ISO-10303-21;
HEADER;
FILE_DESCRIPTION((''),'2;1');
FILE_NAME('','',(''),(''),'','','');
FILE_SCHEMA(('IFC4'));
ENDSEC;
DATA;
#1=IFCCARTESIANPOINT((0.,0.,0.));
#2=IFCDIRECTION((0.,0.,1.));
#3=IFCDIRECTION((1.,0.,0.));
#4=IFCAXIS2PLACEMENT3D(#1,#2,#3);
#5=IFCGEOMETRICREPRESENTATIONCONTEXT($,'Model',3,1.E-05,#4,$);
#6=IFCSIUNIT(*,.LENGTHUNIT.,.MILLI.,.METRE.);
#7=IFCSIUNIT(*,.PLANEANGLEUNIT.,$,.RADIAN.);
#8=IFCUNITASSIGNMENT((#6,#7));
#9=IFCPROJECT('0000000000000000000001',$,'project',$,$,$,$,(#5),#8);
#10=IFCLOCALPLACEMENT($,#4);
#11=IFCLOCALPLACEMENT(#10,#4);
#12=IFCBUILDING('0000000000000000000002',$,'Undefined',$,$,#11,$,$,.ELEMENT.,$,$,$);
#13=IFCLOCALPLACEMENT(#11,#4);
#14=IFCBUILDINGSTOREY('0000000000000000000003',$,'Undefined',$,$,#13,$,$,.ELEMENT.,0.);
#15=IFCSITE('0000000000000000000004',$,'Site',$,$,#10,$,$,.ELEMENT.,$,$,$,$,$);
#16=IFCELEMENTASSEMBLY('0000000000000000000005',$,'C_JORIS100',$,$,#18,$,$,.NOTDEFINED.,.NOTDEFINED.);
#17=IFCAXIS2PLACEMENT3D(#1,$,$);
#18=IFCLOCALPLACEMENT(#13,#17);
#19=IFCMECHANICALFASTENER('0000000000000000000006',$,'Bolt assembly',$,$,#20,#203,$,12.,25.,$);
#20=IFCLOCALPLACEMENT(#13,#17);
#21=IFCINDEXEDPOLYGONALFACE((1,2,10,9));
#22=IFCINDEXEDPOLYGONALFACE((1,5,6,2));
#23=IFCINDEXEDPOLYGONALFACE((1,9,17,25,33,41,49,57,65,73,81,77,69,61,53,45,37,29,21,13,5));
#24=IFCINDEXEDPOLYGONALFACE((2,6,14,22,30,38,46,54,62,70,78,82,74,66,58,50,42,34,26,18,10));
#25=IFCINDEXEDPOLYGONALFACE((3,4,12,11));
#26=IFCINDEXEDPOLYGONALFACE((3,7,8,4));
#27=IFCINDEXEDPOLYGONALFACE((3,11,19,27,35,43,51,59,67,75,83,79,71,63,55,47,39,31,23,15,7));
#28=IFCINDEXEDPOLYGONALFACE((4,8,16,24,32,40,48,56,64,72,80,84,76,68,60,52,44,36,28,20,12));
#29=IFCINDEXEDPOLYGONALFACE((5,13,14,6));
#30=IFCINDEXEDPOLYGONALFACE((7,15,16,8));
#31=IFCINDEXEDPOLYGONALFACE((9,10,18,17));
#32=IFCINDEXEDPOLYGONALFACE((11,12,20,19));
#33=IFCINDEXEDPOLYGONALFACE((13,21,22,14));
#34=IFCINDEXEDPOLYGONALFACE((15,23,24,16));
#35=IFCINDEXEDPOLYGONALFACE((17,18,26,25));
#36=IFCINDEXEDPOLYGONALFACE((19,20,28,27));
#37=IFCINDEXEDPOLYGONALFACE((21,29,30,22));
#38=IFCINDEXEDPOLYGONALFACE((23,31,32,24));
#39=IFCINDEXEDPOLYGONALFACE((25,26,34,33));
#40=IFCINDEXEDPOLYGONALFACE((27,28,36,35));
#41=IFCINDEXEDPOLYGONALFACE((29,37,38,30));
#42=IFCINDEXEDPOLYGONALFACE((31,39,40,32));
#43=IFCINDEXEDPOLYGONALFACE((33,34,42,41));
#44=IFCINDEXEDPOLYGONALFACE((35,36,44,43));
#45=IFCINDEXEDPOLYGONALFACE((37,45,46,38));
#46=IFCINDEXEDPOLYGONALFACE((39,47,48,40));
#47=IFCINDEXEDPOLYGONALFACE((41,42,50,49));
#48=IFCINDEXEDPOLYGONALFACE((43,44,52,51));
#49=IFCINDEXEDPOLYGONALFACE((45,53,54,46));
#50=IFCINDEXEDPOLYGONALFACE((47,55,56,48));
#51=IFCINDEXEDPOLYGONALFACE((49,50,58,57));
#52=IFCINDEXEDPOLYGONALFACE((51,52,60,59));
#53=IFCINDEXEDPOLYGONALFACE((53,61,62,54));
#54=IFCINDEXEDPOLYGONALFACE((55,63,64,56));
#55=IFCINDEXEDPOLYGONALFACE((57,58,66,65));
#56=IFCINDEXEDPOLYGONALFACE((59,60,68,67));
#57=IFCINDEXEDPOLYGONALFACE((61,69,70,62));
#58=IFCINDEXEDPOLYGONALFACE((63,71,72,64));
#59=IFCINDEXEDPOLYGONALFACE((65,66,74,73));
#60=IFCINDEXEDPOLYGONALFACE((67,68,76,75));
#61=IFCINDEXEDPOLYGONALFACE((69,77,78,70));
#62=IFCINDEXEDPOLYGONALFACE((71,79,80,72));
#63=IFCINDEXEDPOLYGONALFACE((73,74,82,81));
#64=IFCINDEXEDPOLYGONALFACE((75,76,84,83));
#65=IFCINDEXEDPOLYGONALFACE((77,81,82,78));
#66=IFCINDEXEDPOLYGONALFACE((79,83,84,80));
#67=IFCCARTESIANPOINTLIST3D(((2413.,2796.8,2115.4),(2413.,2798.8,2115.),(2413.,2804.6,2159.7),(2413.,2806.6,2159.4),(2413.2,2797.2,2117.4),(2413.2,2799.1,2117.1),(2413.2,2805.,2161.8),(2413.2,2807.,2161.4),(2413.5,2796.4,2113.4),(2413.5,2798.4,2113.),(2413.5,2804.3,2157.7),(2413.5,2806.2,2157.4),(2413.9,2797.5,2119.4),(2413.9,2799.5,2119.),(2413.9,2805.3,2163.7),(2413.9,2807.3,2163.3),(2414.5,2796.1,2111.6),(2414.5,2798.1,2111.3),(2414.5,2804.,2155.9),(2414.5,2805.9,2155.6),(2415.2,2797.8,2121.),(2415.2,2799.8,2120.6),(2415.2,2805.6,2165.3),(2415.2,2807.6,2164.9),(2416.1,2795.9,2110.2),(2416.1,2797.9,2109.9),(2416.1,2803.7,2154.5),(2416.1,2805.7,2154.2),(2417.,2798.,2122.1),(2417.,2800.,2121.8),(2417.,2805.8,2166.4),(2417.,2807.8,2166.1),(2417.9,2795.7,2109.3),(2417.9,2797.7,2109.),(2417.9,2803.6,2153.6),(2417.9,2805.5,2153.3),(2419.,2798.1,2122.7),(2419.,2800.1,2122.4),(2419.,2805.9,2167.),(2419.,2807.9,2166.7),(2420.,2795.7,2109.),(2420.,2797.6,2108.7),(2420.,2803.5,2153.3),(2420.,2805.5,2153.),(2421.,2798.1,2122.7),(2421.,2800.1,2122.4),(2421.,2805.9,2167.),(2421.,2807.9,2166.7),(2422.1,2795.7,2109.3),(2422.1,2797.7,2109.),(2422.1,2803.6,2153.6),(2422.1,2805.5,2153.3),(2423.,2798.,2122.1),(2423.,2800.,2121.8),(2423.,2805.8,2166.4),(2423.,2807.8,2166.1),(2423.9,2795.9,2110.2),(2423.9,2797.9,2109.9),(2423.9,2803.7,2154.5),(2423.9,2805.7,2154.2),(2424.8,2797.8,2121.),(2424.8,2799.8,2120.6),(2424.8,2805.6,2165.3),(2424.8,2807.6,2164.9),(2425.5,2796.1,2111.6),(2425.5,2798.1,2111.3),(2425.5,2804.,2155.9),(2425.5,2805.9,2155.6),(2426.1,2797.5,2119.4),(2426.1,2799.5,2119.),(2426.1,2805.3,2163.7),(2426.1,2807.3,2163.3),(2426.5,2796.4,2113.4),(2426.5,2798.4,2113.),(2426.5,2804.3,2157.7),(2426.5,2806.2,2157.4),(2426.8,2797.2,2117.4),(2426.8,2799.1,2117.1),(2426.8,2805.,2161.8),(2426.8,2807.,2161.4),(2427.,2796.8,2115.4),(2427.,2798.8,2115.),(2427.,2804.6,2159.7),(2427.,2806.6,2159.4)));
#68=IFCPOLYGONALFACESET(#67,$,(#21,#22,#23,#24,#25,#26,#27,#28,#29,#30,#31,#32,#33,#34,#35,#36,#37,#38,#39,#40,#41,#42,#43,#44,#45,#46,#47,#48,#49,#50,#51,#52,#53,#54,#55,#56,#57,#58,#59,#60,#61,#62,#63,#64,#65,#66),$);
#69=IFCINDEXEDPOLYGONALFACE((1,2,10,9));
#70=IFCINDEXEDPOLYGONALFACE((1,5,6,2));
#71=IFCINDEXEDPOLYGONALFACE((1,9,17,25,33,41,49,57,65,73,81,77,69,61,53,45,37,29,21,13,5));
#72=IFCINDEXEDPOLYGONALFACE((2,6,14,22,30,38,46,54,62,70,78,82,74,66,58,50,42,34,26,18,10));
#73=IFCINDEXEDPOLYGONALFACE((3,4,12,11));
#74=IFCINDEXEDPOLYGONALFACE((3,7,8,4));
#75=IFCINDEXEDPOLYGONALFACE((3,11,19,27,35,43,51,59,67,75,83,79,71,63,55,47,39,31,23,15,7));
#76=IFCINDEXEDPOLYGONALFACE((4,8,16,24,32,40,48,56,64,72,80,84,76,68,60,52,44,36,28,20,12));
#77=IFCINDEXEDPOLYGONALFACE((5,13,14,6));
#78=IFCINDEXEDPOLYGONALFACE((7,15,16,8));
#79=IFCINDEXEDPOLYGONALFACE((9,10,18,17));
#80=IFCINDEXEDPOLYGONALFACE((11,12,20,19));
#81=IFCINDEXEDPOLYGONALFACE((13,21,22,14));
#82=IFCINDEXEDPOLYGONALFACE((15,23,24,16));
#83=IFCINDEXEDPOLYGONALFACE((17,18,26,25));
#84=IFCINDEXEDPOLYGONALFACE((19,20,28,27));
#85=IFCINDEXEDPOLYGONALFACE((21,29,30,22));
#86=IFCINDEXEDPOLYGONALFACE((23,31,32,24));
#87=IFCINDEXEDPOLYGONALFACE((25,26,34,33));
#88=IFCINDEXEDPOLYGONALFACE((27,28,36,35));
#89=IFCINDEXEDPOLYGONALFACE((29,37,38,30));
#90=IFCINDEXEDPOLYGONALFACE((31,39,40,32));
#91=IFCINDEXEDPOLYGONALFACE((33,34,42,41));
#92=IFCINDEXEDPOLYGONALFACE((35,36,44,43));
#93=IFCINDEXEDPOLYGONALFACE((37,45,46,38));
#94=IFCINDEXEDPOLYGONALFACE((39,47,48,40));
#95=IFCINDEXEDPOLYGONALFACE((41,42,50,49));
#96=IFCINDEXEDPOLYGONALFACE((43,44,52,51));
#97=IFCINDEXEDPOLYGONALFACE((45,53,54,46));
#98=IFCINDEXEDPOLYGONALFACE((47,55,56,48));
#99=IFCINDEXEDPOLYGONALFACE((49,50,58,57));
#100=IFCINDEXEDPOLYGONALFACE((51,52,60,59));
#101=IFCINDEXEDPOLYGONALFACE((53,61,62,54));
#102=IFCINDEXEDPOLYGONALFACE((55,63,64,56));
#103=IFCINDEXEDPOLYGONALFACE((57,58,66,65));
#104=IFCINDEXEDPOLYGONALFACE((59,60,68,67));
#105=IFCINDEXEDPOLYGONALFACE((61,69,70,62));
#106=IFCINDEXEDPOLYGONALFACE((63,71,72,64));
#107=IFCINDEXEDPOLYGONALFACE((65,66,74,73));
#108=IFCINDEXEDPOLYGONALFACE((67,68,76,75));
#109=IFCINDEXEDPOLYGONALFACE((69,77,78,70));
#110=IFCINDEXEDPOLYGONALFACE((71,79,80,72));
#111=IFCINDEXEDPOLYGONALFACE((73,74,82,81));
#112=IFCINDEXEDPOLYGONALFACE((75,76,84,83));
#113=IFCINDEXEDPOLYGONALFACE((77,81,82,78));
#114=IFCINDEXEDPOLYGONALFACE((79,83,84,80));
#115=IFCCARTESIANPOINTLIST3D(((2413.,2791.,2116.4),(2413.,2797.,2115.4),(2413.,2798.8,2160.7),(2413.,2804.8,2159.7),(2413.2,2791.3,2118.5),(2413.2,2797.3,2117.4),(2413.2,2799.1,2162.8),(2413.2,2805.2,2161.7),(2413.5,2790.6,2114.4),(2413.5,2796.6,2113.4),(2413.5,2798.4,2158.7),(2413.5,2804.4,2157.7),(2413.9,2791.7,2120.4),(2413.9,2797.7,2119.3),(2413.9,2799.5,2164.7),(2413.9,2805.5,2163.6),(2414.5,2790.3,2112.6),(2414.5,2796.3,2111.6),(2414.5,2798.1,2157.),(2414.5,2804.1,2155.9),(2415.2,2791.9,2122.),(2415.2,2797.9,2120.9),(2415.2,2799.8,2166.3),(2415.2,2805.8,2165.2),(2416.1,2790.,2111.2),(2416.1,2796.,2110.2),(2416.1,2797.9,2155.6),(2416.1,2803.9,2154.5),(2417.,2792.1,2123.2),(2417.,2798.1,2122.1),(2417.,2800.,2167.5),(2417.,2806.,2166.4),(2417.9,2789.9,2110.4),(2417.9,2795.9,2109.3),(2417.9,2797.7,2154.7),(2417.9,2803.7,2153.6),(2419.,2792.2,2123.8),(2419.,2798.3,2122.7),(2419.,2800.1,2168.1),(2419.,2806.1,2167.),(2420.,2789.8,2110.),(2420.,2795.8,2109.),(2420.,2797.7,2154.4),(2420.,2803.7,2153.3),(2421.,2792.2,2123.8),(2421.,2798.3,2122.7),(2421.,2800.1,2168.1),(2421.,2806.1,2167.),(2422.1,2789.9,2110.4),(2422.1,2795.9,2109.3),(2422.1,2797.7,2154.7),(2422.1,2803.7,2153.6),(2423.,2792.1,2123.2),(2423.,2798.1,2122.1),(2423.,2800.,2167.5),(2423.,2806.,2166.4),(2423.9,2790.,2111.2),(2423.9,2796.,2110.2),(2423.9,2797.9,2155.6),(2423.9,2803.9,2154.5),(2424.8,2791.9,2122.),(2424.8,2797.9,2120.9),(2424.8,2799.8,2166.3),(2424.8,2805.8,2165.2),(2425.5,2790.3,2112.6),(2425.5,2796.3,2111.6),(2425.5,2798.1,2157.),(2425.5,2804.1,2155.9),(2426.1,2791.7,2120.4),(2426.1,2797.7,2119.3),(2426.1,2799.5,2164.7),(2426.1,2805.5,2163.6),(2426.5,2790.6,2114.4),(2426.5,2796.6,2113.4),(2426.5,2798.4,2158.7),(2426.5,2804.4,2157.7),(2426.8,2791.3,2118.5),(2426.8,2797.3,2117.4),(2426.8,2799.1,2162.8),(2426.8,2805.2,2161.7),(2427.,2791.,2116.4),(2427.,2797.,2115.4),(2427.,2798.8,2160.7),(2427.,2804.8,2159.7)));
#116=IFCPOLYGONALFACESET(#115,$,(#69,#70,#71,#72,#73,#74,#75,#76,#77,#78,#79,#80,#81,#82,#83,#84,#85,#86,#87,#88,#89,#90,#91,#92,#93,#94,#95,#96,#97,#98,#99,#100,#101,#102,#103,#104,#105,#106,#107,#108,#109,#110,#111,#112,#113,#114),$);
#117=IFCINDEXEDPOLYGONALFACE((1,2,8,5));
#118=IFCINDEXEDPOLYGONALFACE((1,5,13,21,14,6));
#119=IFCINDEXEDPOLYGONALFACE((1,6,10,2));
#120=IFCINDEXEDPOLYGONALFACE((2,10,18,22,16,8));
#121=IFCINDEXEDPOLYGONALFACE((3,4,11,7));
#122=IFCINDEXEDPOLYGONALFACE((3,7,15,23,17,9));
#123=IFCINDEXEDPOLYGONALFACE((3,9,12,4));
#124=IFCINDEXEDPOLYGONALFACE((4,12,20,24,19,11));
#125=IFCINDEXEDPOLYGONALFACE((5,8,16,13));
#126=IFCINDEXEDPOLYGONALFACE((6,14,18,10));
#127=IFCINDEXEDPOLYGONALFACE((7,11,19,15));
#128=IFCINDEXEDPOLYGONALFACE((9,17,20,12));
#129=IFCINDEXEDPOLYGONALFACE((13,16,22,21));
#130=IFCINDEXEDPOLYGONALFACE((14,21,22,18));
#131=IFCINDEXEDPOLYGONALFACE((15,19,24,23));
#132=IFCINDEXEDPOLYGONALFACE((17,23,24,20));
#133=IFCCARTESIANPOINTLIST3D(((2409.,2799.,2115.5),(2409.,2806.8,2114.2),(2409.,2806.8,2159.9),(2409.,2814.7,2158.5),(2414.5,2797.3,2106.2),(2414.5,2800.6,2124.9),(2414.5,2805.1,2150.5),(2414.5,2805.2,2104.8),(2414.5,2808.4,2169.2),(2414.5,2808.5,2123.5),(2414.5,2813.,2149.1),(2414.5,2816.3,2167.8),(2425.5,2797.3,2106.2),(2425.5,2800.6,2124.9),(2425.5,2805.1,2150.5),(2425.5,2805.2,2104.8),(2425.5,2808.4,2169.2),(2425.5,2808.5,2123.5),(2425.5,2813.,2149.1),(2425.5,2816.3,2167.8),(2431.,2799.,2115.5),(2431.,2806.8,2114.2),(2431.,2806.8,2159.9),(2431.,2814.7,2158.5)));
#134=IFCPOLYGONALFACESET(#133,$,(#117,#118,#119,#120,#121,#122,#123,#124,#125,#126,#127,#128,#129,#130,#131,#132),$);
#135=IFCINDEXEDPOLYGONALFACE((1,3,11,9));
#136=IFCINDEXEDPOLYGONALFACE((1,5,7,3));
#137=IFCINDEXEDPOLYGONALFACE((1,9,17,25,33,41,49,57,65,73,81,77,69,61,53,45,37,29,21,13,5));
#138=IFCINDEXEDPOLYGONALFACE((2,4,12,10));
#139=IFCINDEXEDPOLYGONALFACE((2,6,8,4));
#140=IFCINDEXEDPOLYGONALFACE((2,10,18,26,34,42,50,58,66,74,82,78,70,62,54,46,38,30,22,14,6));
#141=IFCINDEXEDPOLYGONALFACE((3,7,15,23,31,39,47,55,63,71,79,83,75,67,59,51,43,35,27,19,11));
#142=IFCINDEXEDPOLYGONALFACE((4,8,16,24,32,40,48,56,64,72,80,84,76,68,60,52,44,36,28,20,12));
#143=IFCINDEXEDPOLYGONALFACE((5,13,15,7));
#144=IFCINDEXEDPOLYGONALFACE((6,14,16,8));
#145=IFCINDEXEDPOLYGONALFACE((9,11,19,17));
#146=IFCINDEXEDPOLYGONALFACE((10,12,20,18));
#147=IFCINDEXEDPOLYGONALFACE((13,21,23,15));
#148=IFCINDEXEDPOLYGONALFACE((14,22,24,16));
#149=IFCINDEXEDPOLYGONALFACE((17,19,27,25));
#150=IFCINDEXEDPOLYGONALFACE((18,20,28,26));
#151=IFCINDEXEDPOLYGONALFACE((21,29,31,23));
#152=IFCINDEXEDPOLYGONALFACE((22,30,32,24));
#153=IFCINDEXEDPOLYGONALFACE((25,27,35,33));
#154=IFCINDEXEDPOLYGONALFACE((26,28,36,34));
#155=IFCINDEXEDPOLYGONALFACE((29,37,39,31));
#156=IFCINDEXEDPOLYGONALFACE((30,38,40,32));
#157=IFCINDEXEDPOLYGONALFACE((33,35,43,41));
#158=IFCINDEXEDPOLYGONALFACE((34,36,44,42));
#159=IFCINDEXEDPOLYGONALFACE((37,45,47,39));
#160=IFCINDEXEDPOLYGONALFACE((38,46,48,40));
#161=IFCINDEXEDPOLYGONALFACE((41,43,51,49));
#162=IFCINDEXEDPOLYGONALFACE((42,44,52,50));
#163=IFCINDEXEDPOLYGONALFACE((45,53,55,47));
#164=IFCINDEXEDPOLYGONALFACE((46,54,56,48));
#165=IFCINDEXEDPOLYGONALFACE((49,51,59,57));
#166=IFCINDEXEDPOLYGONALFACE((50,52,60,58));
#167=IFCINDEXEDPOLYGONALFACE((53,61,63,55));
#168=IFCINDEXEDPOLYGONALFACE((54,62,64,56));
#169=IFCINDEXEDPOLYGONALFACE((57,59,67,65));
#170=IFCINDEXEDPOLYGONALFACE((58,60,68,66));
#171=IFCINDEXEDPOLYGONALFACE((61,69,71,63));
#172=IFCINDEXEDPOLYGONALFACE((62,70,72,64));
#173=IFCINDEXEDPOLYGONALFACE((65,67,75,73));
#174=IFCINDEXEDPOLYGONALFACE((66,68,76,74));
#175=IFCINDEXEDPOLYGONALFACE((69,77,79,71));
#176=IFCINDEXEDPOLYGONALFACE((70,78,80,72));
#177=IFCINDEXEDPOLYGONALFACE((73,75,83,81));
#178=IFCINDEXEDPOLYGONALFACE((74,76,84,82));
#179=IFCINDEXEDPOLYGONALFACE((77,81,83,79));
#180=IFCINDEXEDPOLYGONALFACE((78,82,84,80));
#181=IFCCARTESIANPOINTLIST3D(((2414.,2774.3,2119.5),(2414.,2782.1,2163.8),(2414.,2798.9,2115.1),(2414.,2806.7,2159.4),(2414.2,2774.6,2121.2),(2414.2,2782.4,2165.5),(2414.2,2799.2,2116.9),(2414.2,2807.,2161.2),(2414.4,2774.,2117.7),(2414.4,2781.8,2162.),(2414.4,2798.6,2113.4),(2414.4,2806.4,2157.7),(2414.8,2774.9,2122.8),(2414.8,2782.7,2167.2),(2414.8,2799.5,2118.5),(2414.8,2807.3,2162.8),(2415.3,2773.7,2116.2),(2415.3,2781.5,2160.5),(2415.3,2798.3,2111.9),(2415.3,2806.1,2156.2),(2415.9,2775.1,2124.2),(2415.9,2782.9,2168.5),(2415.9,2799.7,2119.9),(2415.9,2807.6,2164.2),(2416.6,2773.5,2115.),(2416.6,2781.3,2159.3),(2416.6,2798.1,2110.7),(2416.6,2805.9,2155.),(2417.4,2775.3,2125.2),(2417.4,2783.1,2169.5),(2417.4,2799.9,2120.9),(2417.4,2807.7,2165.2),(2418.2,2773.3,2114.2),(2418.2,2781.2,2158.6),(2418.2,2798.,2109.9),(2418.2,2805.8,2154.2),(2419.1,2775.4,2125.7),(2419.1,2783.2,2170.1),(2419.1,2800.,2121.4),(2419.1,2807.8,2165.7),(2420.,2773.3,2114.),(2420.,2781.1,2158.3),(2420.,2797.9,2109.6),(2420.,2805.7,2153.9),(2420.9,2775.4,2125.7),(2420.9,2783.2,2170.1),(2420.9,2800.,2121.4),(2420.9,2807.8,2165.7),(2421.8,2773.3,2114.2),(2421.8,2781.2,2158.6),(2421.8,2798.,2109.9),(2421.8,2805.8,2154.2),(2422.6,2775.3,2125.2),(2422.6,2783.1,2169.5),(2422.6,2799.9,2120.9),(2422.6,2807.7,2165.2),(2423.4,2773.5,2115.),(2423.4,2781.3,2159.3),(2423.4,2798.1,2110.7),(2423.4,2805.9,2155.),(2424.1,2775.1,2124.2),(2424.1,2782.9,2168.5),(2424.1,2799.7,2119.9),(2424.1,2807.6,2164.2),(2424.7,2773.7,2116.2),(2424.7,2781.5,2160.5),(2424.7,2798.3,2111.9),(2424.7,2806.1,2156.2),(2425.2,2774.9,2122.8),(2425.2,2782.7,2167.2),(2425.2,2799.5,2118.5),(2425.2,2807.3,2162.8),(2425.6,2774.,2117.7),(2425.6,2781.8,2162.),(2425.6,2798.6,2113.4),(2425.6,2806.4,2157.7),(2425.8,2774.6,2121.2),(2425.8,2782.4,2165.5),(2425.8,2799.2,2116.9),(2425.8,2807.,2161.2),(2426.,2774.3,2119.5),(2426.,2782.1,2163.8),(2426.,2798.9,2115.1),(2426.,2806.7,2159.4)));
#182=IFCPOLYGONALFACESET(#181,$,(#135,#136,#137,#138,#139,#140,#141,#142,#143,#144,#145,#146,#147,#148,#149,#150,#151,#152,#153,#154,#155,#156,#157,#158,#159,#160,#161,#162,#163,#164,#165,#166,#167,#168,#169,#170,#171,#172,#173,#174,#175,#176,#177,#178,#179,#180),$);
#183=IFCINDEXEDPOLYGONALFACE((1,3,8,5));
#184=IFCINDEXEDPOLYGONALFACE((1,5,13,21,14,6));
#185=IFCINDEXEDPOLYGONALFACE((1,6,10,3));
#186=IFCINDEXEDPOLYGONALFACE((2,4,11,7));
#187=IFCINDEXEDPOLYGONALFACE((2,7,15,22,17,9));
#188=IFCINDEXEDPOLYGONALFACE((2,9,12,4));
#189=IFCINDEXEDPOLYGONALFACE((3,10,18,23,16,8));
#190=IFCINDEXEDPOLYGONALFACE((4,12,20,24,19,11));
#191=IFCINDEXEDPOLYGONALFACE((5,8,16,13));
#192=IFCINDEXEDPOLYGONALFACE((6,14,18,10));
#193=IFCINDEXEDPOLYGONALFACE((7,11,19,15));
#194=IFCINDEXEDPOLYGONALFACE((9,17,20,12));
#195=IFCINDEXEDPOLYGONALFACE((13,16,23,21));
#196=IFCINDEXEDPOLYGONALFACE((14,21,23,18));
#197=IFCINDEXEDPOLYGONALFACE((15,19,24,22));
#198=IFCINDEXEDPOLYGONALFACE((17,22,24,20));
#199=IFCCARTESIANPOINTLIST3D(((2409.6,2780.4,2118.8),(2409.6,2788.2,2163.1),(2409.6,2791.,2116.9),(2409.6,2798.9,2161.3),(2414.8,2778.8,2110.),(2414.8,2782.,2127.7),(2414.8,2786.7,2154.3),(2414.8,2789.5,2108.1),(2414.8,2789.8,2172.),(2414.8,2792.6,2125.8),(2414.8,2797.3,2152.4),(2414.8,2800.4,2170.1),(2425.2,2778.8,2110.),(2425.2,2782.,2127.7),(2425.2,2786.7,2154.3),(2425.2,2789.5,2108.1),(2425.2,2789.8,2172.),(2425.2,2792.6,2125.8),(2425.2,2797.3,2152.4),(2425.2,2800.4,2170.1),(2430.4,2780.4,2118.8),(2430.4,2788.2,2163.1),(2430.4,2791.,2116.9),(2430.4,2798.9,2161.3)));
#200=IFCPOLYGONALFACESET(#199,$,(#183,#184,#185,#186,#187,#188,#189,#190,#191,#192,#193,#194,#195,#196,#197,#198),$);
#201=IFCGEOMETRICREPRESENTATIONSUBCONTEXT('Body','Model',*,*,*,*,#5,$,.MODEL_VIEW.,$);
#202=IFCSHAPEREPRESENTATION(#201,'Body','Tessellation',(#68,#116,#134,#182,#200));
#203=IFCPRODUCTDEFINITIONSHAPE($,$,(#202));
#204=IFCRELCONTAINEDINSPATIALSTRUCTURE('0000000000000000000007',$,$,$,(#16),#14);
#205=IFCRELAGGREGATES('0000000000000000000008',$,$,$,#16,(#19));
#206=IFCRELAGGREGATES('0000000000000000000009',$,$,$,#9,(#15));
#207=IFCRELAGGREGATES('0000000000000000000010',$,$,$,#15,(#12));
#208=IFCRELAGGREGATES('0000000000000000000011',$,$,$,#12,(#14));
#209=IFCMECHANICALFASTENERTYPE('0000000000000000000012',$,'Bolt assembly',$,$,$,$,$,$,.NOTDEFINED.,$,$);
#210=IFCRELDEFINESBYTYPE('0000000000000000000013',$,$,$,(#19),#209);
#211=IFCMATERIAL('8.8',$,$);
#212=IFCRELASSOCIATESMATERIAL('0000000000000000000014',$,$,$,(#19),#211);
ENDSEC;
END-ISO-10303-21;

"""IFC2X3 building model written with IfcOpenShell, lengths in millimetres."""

from ifc_helpers import new_model, si_unit, frame, origin_with_axes, origin_2d_with_axis, place, context, subcontext, project, spatial, polyline, circle, outline, extrude, source, transform, mapped, material, type_object, element, aggregate, save


model = new_model("IFC2X3")

# Units and contexts
model_context = context("Model", 3, precision=1e-05, world=origin_with_axes())
body_context = subcontext(model_context, "Body", "Model", "MODEL_VIEW")
ifc_project = project(units=[si_unit("LENGTHUNIT", "METRE", prefix="MILLI"), si_unit("PLANEANGLEUNIT", "RADIAN")], contexts=[model_context])

# Site, building, storey
site_placement = place(None, origin_with_axes())
site = spatial("IfcSite", under=ifc_project, at=site_placement, Name="Site", CompositionType="ELEMENT")
building_placement = place(site_placement, origin_with_axes())
building = spatial("IfcBuilding", under=site, at=building_placement, Name="Undefined", CompositionType="ELEMENT")
storey_placement = place(building_placement, origin_with_axes())
storey = spatial("IfcBuildingStorey", under=building, at=storey_placement, Name="Undefined", CompositionType="ELEMENT", Elevation=0.0)

# Element assembly
assembly_1_placement = place(storey_placement, origin_with_axes())
assembly_1 = element("IfcElementAssembly", 1, at=assembly_1_placement, inside=storey, Name="C_JORIS100", AssemblyPlace="NOTDEFINED", PredefinedType="NOTDEFINED")

# Shared definitions
mechanical_fastener_type = type_object("IfcMechanicalFastenerType", Name="Bolt assembly")
ifc_material_1 = material(Name="8.8")

# Mechanical fastener
shared_shape_1 = source(origin_with_axes(), body_context, "Body", "SweptSolid", [
    extrude(circle(Radius=7.0, at=origin_2d_with_axis()), frame((0.0, 0.1, 0.0), z_axis=(0.0, 1.0, 0.0), x_axis=(1.0, 0.0, 0.0)), (0.0, 0.0, 1.0), 2.0),
    extrude(circle(Radius=7.0, at=origin_2d_with_axis()), frame((0.0, 1.9, 0.0), z_axis=(0.0, 1.0, 0.0), x_axis=(1.0, 0.0, 0.0)), (0.0, 0.0, 1.0), 6.1),
    extrude(outline(polyline([(9.5, -5.5), (9.5, 5.5), (0.0, 11.0), (-9.5, 5.5), (-9.5, -5.5), (0.0, -11.0), (9.5, -5.5)])), frame((0.0, -8.0, 0.0), z_axis=(0.0, 1.0, 0.0), x_axis=(1.0, 0.0, 0.0)), (0.0, 0.0, 1.0), 8.0),
    extrude(circle(Radius=6.0, at=origin_2d_with_axis()), frame((0.0, 0.0, 0.0), z_axis=(0.0, 1.0, 0.0), x_axis=(1.0, 0.0, 0.0)), (0.0, 0.0, 1.0), 25.0),
    extrude(outline(polyline([(9.0, -5.2), (9.0, 5.2), (0.0, 10.4), (-9.0, 5.2), (-9.0, -5.2), (0.0, -10.4), (9.0, -5.2)])), frame((0.0, 8.0, 0.0), z_axis=(0.0, 1.0, 0.0), x_axis=(1.0, 0.0, 0.0)), (0.0, 0.0, 1.0), 10.8),
])
mechanical_fastener_1_placement = place(assembly_1_placement, frame((2420.0, 2806.8, 2159.9), z_axis=(-1.0, 0.0, 0.0), x_axis=(0.0, -0.174019, -0.984742)))
mechanical_fastener_1 = element("IfcMechanicalFastener", 2, at=mechanical_fastener_1_placement, type_object=mechanical_fastener_type, material=ifc_material_1, Name="Bolt assembly", NominalDiameter=12.0, NominalLength=25.0, context=body_context, shape_type="MappedRepresentation", body=[
    mapped(shared_shape_1, transform((0.0, 0.0, 0.0))),
    mapped(shared_shape_1, transform((45.0, 0.0, 0.0))),
])
aggregate(assembly_1, [mechanical_fastener_1])

save(model, "model.ifc")
